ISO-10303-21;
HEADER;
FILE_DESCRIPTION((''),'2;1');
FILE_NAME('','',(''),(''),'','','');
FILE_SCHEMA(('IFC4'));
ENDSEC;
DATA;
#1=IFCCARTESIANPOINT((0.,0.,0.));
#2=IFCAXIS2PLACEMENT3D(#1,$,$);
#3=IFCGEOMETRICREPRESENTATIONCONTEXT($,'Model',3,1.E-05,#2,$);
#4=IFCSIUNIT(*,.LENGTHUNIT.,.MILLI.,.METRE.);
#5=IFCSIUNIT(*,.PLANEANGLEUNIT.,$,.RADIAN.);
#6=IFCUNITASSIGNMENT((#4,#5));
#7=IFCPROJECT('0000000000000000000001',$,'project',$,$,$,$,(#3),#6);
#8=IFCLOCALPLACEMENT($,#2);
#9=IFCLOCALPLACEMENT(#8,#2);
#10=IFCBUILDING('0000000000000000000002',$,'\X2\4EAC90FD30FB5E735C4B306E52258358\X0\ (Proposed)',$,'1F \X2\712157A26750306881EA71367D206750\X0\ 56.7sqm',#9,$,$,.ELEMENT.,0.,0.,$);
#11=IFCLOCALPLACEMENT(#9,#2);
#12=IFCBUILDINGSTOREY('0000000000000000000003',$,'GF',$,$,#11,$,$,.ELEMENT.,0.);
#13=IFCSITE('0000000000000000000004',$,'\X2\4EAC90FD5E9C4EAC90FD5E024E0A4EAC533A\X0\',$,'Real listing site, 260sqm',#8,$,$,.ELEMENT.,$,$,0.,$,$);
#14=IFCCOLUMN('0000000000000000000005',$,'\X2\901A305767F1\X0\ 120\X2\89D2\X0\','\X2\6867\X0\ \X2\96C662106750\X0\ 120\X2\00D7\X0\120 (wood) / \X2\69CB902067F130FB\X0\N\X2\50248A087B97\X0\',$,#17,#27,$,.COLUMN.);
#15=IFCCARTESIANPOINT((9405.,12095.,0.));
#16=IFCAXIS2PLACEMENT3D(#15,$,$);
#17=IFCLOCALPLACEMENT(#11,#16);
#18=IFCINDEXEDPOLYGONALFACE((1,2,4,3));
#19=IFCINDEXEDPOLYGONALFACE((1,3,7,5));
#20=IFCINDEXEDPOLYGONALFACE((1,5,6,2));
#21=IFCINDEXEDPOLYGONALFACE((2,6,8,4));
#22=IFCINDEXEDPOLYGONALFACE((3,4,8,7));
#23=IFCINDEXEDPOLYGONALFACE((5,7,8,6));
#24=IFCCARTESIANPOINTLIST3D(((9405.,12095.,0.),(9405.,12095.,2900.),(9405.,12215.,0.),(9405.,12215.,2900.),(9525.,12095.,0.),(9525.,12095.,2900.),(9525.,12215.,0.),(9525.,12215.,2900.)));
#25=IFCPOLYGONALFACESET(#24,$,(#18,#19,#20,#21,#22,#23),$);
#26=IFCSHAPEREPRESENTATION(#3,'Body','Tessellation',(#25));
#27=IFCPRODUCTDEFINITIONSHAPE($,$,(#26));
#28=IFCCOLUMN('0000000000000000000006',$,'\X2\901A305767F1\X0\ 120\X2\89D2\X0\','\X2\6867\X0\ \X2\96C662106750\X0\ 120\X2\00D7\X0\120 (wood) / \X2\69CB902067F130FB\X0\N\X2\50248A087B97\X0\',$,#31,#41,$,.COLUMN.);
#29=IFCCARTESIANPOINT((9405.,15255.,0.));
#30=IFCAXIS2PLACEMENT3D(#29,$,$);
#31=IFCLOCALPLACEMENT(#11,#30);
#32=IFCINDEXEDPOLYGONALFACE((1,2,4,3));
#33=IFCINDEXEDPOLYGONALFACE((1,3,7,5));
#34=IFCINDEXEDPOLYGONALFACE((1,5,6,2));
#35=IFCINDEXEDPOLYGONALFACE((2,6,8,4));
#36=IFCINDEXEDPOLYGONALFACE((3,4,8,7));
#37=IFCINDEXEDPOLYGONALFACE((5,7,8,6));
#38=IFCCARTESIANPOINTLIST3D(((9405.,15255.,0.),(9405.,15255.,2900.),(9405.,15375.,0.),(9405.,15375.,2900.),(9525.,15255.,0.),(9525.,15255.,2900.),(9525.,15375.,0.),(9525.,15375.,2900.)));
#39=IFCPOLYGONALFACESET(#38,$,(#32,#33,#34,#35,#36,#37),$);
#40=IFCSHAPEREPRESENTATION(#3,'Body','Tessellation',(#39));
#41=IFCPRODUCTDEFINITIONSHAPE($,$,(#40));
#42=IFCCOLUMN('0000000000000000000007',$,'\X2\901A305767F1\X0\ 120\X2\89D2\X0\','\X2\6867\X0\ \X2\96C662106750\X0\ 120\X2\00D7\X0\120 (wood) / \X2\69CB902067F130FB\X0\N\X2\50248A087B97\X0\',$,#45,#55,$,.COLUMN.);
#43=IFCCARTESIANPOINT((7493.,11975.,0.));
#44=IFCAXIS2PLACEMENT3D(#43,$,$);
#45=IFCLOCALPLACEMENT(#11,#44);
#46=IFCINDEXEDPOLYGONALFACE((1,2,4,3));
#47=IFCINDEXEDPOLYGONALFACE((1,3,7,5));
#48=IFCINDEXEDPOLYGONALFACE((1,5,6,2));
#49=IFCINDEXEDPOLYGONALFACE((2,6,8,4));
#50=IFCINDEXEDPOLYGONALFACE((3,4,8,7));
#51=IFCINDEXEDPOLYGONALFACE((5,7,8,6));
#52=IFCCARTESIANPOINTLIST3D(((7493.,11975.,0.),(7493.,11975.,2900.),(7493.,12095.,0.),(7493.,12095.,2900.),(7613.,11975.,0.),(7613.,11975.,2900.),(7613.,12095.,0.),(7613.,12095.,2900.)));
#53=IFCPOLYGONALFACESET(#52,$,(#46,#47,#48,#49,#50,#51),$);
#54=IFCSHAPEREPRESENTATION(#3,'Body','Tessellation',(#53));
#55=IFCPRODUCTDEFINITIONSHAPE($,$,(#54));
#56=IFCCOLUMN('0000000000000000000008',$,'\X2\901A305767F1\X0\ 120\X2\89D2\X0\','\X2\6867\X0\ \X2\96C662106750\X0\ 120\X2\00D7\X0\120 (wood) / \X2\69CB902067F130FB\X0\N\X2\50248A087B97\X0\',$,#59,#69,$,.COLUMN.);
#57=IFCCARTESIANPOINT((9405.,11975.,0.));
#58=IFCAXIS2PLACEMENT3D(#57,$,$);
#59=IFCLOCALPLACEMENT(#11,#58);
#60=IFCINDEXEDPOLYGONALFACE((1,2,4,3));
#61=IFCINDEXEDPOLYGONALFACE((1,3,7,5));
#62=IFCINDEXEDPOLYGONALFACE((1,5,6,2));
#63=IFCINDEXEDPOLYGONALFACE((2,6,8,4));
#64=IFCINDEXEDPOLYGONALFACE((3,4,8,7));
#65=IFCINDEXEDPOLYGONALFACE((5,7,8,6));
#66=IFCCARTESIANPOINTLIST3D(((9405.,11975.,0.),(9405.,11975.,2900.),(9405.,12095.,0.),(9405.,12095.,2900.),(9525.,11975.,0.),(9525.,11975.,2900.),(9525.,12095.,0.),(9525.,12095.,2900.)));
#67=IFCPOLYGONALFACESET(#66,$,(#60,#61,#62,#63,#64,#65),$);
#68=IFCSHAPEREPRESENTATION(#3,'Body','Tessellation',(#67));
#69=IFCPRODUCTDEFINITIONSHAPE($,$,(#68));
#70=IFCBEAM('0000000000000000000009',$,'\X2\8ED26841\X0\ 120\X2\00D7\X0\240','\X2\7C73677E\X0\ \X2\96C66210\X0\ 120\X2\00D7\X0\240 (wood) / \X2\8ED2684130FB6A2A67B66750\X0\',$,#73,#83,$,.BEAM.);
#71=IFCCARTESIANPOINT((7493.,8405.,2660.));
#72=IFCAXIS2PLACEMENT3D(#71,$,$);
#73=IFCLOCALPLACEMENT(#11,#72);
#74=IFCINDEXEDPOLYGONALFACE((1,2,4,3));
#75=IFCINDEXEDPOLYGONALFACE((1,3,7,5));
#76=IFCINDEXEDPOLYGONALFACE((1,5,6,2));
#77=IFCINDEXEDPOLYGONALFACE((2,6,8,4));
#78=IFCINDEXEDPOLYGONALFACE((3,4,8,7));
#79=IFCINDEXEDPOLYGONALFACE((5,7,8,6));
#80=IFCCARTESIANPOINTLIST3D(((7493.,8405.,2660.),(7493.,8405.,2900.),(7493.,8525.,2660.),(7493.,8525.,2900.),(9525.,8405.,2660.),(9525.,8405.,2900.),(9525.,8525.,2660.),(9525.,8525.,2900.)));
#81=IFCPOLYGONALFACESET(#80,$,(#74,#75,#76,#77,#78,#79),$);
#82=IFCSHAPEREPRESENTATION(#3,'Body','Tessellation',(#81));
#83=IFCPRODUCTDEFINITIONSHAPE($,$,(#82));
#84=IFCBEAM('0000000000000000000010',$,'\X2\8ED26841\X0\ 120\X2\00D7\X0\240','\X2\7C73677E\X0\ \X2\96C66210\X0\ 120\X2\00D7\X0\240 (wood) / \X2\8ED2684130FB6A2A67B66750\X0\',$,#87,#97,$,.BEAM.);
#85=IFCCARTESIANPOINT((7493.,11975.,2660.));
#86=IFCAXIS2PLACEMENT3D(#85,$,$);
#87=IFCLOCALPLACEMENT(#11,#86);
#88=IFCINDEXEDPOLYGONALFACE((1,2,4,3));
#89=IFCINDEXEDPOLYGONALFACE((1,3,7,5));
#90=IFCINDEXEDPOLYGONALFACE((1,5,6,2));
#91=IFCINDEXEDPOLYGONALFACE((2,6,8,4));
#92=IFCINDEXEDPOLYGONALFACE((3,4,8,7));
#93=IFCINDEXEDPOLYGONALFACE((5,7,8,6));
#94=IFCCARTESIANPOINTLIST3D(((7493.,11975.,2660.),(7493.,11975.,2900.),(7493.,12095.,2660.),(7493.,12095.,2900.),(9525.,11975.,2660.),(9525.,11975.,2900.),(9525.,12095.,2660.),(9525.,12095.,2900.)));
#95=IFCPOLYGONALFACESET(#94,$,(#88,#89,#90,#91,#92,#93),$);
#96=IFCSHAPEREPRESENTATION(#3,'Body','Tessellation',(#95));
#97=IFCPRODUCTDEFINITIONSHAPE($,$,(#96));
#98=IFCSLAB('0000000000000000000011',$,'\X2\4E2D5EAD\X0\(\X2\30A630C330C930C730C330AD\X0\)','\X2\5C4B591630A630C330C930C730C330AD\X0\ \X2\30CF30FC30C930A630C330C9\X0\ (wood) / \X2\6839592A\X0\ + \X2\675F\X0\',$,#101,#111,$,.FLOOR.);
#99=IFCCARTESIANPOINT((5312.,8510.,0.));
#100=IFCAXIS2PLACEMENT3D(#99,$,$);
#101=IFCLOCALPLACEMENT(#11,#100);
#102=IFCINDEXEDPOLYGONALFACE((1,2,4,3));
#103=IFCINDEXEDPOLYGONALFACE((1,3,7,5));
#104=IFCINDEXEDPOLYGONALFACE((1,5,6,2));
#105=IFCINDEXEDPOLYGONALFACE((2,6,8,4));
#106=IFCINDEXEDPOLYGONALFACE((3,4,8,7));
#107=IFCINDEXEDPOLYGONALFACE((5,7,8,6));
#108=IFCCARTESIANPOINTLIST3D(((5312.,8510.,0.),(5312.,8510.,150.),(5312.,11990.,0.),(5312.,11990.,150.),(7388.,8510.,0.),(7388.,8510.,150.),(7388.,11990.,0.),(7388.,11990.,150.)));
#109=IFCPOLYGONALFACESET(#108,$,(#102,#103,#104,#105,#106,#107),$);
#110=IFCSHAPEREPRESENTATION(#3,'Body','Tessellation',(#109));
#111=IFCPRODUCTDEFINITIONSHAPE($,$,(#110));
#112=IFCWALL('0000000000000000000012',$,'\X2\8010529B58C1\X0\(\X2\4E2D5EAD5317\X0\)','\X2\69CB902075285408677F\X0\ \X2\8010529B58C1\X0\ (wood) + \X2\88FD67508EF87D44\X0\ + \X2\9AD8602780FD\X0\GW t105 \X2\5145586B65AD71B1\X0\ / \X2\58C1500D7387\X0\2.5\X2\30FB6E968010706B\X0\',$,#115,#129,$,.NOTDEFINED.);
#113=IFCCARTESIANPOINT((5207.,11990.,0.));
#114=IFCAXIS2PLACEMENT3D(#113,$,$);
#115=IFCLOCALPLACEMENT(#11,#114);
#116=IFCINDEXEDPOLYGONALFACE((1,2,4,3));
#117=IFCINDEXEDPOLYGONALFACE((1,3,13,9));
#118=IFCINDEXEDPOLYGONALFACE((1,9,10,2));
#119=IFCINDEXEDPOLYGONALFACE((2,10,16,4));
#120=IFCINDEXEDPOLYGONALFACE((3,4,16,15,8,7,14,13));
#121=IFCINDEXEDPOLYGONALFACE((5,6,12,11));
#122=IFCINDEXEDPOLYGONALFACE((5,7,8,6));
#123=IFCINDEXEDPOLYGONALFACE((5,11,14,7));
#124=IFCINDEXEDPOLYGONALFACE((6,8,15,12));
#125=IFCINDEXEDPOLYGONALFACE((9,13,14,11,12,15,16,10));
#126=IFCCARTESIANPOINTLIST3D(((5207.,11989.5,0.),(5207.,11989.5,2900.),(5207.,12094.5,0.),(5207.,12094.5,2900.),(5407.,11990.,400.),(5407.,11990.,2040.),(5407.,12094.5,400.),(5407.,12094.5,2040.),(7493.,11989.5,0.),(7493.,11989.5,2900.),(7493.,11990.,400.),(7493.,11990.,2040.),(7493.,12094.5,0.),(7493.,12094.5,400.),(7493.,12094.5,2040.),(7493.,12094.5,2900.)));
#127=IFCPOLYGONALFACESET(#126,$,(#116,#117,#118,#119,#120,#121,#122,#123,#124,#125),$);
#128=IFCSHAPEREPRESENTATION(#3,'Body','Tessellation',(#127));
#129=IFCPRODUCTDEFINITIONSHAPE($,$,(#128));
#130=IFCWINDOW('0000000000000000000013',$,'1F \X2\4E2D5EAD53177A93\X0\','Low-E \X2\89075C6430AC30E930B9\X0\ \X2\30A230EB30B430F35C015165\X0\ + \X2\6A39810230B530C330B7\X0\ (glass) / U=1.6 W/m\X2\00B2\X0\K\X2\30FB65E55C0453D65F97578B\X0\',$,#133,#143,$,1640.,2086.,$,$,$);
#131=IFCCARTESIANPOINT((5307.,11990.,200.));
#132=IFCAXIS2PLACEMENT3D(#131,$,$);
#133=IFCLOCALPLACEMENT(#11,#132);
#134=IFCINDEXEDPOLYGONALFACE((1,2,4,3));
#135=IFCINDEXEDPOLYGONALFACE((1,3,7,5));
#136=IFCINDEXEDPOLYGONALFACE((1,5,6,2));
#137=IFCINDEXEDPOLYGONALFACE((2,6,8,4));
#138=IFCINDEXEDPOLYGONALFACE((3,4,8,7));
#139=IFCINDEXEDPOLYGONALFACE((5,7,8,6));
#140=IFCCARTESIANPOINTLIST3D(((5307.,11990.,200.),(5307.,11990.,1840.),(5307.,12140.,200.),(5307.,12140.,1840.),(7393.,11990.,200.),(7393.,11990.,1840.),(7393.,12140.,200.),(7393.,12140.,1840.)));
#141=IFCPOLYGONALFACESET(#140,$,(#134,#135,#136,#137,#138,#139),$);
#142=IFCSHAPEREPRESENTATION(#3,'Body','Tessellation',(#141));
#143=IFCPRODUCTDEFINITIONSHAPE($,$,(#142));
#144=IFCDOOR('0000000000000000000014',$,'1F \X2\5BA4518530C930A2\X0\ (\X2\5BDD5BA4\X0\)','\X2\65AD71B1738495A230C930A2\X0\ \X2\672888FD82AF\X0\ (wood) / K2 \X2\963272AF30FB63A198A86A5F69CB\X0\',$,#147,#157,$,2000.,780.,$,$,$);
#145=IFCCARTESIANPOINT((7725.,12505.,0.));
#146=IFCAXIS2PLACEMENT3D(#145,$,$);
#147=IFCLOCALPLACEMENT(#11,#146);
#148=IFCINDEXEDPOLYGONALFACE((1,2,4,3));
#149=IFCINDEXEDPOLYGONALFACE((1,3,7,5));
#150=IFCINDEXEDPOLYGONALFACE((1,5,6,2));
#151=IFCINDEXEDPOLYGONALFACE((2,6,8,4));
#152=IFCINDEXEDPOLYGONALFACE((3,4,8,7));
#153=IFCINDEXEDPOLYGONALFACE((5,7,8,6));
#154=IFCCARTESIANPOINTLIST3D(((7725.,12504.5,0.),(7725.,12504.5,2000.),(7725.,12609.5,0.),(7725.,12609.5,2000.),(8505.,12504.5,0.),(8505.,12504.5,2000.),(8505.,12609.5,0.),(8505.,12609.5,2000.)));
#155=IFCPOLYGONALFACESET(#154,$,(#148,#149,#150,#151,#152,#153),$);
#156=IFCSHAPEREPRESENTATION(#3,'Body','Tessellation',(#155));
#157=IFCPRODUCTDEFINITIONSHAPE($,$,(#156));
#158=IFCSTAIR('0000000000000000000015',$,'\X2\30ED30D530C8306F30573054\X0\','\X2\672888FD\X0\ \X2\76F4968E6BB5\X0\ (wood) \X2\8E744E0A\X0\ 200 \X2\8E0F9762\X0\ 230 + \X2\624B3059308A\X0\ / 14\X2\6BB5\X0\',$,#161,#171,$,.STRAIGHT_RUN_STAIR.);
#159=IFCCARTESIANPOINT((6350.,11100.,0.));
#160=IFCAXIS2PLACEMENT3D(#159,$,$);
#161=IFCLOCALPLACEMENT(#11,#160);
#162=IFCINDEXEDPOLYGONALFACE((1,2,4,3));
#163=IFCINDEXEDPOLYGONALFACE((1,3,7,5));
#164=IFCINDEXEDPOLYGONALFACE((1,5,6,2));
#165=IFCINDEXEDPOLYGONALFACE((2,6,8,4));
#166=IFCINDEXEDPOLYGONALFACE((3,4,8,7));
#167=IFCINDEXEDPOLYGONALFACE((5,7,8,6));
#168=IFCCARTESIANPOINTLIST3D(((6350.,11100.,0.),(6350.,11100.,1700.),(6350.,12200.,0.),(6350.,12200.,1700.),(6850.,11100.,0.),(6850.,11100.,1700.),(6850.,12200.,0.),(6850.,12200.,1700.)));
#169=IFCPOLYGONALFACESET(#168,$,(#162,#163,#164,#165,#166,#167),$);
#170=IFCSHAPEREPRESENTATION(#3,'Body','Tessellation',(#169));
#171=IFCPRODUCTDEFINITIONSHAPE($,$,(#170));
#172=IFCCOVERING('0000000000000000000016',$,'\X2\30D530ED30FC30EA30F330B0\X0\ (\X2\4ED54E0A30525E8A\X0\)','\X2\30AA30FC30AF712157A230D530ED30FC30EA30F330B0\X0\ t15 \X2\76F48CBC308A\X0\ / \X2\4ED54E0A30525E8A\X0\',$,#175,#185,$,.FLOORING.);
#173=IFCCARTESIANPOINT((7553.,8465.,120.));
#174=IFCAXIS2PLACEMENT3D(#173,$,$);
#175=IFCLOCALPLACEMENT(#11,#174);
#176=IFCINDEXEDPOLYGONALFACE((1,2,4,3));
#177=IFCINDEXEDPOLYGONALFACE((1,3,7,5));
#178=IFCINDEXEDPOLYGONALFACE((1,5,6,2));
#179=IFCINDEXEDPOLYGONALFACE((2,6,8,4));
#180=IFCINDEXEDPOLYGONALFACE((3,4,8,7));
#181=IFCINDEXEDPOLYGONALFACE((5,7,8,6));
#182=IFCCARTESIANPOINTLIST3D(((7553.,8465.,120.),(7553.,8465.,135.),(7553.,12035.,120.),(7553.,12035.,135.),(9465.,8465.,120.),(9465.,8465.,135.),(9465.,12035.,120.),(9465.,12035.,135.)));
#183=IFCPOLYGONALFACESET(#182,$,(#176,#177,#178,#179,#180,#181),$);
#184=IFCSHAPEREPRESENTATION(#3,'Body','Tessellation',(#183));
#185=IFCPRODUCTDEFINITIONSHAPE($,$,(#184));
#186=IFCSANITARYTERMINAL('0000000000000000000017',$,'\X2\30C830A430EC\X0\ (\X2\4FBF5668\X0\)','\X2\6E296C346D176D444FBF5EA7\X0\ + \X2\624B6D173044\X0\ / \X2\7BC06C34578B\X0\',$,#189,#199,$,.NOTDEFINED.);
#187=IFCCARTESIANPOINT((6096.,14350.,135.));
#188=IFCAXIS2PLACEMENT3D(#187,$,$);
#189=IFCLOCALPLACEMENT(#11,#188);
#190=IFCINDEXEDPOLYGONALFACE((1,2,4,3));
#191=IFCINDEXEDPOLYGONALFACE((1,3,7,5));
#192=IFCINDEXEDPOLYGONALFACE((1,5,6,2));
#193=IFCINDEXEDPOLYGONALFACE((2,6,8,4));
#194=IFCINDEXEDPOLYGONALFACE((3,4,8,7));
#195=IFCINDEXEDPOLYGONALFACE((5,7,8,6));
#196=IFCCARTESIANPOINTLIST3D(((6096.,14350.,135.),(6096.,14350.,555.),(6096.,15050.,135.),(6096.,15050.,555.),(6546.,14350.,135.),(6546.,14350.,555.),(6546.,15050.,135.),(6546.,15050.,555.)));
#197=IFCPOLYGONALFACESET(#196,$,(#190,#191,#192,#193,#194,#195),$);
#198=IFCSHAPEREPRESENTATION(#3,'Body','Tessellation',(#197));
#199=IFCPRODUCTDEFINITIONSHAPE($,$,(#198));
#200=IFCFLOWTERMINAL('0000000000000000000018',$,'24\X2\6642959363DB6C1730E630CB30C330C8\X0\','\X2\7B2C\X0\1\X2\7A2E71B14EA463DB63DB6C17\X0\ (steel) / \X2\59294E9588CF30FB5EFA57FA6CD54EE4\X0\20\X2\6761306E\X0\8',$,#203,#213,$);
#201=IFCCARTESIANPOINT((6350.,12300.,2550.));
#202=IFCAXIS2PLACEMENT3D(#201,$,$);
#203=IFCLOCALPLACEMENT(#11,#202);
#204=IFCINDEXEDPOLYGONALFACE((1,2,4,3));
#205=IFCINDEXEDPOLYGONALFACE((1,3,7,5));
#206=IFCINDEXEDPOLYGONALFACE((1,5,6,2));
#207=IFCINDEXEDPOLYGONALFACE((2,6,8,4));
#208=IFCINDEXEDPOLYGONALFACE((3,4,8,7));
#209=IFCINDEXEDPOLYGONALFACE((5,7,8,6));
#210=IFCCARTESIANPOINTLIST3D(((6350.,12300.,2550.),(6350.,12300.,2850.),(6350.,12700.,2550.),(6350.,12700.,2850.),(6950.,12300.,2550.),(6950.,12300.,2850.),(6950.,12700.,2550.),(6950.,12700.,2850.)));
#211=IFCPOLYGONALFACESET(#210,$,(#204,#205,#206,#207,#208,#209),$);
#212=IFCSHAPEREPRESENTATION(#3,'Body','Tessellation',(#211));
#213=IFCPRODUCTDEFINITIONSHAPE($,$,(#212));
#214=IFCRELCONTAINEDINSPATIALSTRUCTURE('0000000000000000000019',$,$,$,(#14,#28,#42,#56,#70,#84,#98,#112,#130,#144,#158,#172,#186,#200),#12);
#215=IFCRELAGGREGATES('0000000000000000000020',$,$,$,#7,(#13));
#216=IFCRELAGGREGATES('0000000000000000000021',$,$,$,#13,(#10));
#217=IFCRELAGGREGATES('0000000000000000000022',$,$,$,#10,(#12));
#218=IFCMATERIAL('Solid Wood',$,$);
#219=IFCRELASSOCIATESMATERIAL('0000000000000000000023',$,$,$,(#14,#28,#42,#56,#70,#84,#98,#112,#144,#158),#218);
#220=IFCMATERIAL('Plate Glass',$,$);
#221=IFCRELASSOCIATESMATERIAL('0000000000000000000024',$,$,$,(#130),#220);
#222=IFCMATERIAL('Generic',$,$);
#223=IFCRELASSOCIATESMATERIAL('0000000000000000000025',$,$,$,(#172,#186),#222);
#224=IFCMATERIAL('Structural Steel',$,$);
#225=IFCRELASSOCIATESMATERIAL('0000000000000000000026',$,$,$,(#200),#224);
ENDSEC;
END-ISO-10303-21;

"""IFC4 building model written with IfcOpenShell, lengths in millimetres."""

from ifc_helpers import new_model, si_unit, frame, frame_2d, origin, place, context, project, spatial, rectangle, extrude, material, element, fill, save


model = new_model("IFC4")

# Units and contexts
model_context = context("Model", 3, precision=1e-05, world=origin())
ifc_project = project(units=[si_unit("LENGTHUNIT", "METRE", prefix="MILLI"), si_unit("PLANEANGLEUNIT", "RADIAN")], contexts=[model_context])

# Site, building, storey
site_placement = place(None, origin())
site = spatial("IfcSite", under=ifc_project, at=site_placement, Name="京都府京都市上京区", ObjectType="Real listing site, 260sqm", CompositionType="ELEMENT", RefElevation=0.0)
building_placement = place(site_placement, origin())
building = spatial("IfcBuilding", under=site, at=building_placement, Name="京都・平屋の別荘 (Proposed)", ObjectType="1F 無垢材と自然素材 56.7sqm", CompositionType="ELEMENT", ElevationOfRefHeight=0.0, ElevationOfTerrain=0.0)
storey_placement = place(building_placement, origin())
storey = spatial("IfcBuildingStorey", under=building, at=storey_placement, Name="GF", CompositionType="ELEMENT", Elevation=0.0)

# Columns
ifc_material_1 = material(Name="Solid Wood")
column_1_placement = place(storey_placement, frame((9405.0, 12095.0, 0.0)))
element("IfcColumn", 1, at=column_1_placement, inside=storey, material=ifc_material_1, Name="通し柱 120角", Description="桧 集成材 120×120 (wood) / 構造柱・N値計算", PredefinedType="COLUMN", context=model_context, shape_type="SweptSolid", body=[
    extrude(rectangle(XDim=120.0, YDim=120.0, at=frame_2d((60.0, 60.0))), frame((9405.0, 12095.0, 0.0)), (0.0, 0.0, 1.0), 2900.0),
])
column_2_placement = place(storey_placement, frame((9405.0, 15255.0, 0.0)))
element("IfcColumn", 2, at=column_2_placement, inside=storey, material=ifc_material_1, Name="通し柱 120角", Description="桧 集成材 120×120 (wood) / 構造柱・N値計算", PredefinedType="COLUMN", context=model_context, shape_type="SweptSolid", body=[
    extrude(rectangle(XDim=120.0, YDim=120.0, at=frame_2d((60.0, 60.0))), frame((9405.0, 15255.0, 0.0)), (0.0, 0.0, 1.0), 2900.0),
])
column_3_placement = place(storey_placement, frame((7493.0, 11975.0, 0.0)))
element("IfcColumn", 3, at=column_3_placement, inside=storey, material=ifc_material_1, Name="通し柱 120角", Description="桧 集成材 120×120 (wood) / 構造柱・N値計算", PredefinedType="COLUMN", context=model_context, shape_type="SweptSolid", body=[
    extrude(rectangle(XDim=120.0, YDim=120.0, at=frame_2d((60.0, 60.0))), frame((7493.0, 11975.0, 0.0)), (0.0, 0.0, 1.0), 2900.0),
])
column_4_placement = place(storey_placement, frame((9405.0, 11975.0, 0.0)))
element("IfcColumn", 4, at=column_4_placement, inside=storey, material=ifc_material_1, Name="通し柱 120角", Description="桧 集成材 120×120 (wood) / 構造柱・N値計算", PredefinedType="COLUMN", context=model_context, shape_type="SweptSolid", body=[
    extrude(rectangle(XDim=120.0, YDim=120.0, at=frame_2d((60.0, 60.0))), frame((9405.0, 11975.0, 0.0)), (0.0, 0.0, 1.0), 2900.0),
])

# Beams
beam_1_placement = place(storey_placement, frame((7493.0, 8405.0, 2660.0)))
element("IfcBeam", 5, at=beam_1_placement, inside=storey, material=ifc_material_1, Name="軒桁 120×240", Description="米松 集成 120×240 (wood) / 軒桁・横架材", PredefinedType="BEAM", context=model_context, shape_type="SweptSolid", body=[
    extrude(rectangle(XDim=2032.0, YDim=120.0, at=frame_2d((1016.0, 60.0))), frame((7493.0, 8405.0, 2660.0)), (0.0, 0.0, 1.0), 240.0),
])
beam_2_placement = place(storey_placement, frame((7493.0, 11975.0, 2660.0)))
element("IfcBeam", 6, at=beam_2_placement, inside=storey, material=ifc_material_1, Name="軒桁 120×240", Description="米松 集成 120×240 (wood) / 軒桁・横架材", PredefinedType="BEAM", context=model_context, shape_type="SweptSolid", body=[
    extrude(rectangle(XDim=2032.0, YDim=120.0, at=frame_2d((1016.0, 60.0))), frame((7493.0, 11975.0, 2660.0)), (0.0, 0.0, 1.0), 240.0),
])

# Slab
slab_placement = place(storey_placement, frame((5312.0, 8510.0, 0.0)))
element("IfcSlab", 7, at=slab_placement, inside=storey, material=ifc_material_1, Name="中庭(ウッドデッキ)", Description="屋外ウッドデッキ ハードウッド (wood) / 根太 + 束", PredefinedType="FLOOR", context=model_context, shape_type="SweptSolid", body=[
    extrude(rectangle(XDim=2076.0, YDim=3480.0, at=frame_2d((1038.0, 1740.0))), frame((5312.0, 8510.0, 0.0)), (0.0, 0.0, 1.0), 150.0),
])

# Wall, opening, window
wall_1_placement = place(storey_placement, frame((5207.0, 11990.0, 0.0)))
wall_1 = element("IfcWall", 8, at=wall_1_placement, inside=storey, material=ifc_material_1, Name="耐力壁(中庭北)", Description="構造用合板 耐力壁 (wood) + 製材軸組 + 高性能GW t105 充填断熱 / 壁倍率2.5・準耐火", PredefinedType="NOTDEFINED", context=model_context, shape_type="SweptSolid", body=[
    extrude(rectangle(XDim=2286.0, YDim=105.0, at=frame_2d((1143.0, 52.0))), frame((5207.0, 11990.0, 0.0)), (0.0, 0.0, 1.0), 2900.0),
])
opening_placement = place(storey_placement, frame((5307.0, 11990.0, 200.0)))
opening = element("IfcOpeningElement", 9, at=opening_placement, cuts=wall_1, PredefinedType="NOTDEFINED", context=model_context, shape_type="SweptSolid", body=[
    extrude(rectangle(XDim=2086.0, YDim=150.0, at=frame_2d((1043.0, 75.0))), frame((5307.0, 11990.0, 200.0)), (0.0, 0.0, 1.0), 1640.0),
])
ifc_material_2 = material(Name="Plate Glass")
window_placement = place(storey_placement, frame((5307.0, 11990.0, 200.0)))
window = element("IfcWindow", 10, at=window_placement, inside=storey, material=ifc_material_2, Name="1F 中庭北窓", Description="Low-E 複層ガラス アルゴン封入 + 樹脂サッシ (glass) / U=1.6 W/m²K・日射取得型", OverallHeight=1640.0, OverallWidth=2086.0, context=model_context, shape_type="SweptSolid", body=[
    extrude(rectangle(XDim=2086.0, YDim=150.0, at=frame_2d((1043.0, 75.0))), frame((5307.0, 11990.0, 200.0)), (0.0, 0.0, 1.0), 1640.0),
])
fill(opening, window)

# Door
door_placement = place(storey_placement, frame((7725.0, 12505.0, 0.0)))
element("IfcDoor", 11, at=door_placement, inside=storey, material=ifc_material_1, Name="1F 室内ドア (寝室)", Description="断熱玄関ドア 木製芯 (wood) / K2 防犯・採風機構", OverallHeight=2000.0, OverallWidth=780.0, context=model_context, shape_type="SweptSolid", body=[
    extrude(rectangle(XDim=780.0, YDim=105.0, at=frame_2d((390.0, 52.0))), frame((7725.0, 12505.0, 0.0)), (0.0, 0.0, 1.0), 2000.0),
])

# Stair
stair_placement = place(storey_placement, frame((6350.0, 11100.0, 0.0)))
element("IfcStair", 12, at=stair_placement, inside=storey, material=ifc_material_1, Name="ロフトはしご", Description="木製 直階段 (wood) 蹴上 200 踏面 230 + 手すり / 14段", PredefinedType="STRAIGHT_RUN_STAIR", context=model_context, shape_type="SweptSolid", body=[
    extrude(rectangle(XDim=500.0, YDim=1100.0, at=frame_2d((250.0, 550.0))), frame((6350.0, 11100.0, 0.0)), (0.0, 0.0, 1.0), 1700.0),
])

# Covering
ifc_material_3 = material(Name="Generic")
covering_placement = place(storey_placement, frame((7553.0, 8465.0, 120.0)))
element("IfcCovering", 13, at=covering_placement, inside=storey, material=ifc_material_3, Name="フローリング (仕上げ床)", Description="オーク無垢フローリング t15 直貼り / 仕上げ床", PredefinedType="FLOORING", context=model_context, shape_type="SweptSolid", body=[
    extrude(rectangle(XDim=1912.0, YDim=3570.0, at=frame_2d((956.0, 1785.0))), frame((7553.0, 8465.0, 120.0)), (0.0, 0.0, 1.0), 15.0),
])

# Sanitary terminal
sanitary_terminal_placement = place(storey_placement, frame((6096.0, 14350.0, 135.0)))
element("IfcSanitaryTerminal", 14, at=sanitary_terminal_placement, inside=storey, material=ifc_material_3, Name="トイレ (便器)", Description="温水洗浄便座 + 手洗い / 節水型", PredefinedType="NOTDEFINED", context=model_context, shape_type="SweptSolid", body=[
    extrude(rectangle(XDim=450.0, YDim=700.0, at=frame_2d((225.0, 350.0))), frame((6096.0, 14350.0, 135.0)), (0.0, 0.0, 1.0), 420.0),
])

# Flow terminal
ifc_material_4 = material(Name="Structural Steel")
flow_terminal_placement = place(storey_placement, frame((6350.0, 12300.0, 2550.0)))
element("IfcFlowTerminal", 15, at=flow_terminal_placement, inside=storey, material=ifc_material_4, Name="24時間換気ユニット", Description="第1種熱交換換気 (steel) / 天井裏・建基法令20条の8", context=model_context, shape_type="SweptSolid", body=[
    extrude(rectangle(XDim=600.0, YDim=400.0, at=frame_2d((300.0, 200.0))), frame((6350.0, 12300.0, 2550.0)), (0.0, 0.0, 1.0), 300.0),
])

save(model, "model.ifc")
